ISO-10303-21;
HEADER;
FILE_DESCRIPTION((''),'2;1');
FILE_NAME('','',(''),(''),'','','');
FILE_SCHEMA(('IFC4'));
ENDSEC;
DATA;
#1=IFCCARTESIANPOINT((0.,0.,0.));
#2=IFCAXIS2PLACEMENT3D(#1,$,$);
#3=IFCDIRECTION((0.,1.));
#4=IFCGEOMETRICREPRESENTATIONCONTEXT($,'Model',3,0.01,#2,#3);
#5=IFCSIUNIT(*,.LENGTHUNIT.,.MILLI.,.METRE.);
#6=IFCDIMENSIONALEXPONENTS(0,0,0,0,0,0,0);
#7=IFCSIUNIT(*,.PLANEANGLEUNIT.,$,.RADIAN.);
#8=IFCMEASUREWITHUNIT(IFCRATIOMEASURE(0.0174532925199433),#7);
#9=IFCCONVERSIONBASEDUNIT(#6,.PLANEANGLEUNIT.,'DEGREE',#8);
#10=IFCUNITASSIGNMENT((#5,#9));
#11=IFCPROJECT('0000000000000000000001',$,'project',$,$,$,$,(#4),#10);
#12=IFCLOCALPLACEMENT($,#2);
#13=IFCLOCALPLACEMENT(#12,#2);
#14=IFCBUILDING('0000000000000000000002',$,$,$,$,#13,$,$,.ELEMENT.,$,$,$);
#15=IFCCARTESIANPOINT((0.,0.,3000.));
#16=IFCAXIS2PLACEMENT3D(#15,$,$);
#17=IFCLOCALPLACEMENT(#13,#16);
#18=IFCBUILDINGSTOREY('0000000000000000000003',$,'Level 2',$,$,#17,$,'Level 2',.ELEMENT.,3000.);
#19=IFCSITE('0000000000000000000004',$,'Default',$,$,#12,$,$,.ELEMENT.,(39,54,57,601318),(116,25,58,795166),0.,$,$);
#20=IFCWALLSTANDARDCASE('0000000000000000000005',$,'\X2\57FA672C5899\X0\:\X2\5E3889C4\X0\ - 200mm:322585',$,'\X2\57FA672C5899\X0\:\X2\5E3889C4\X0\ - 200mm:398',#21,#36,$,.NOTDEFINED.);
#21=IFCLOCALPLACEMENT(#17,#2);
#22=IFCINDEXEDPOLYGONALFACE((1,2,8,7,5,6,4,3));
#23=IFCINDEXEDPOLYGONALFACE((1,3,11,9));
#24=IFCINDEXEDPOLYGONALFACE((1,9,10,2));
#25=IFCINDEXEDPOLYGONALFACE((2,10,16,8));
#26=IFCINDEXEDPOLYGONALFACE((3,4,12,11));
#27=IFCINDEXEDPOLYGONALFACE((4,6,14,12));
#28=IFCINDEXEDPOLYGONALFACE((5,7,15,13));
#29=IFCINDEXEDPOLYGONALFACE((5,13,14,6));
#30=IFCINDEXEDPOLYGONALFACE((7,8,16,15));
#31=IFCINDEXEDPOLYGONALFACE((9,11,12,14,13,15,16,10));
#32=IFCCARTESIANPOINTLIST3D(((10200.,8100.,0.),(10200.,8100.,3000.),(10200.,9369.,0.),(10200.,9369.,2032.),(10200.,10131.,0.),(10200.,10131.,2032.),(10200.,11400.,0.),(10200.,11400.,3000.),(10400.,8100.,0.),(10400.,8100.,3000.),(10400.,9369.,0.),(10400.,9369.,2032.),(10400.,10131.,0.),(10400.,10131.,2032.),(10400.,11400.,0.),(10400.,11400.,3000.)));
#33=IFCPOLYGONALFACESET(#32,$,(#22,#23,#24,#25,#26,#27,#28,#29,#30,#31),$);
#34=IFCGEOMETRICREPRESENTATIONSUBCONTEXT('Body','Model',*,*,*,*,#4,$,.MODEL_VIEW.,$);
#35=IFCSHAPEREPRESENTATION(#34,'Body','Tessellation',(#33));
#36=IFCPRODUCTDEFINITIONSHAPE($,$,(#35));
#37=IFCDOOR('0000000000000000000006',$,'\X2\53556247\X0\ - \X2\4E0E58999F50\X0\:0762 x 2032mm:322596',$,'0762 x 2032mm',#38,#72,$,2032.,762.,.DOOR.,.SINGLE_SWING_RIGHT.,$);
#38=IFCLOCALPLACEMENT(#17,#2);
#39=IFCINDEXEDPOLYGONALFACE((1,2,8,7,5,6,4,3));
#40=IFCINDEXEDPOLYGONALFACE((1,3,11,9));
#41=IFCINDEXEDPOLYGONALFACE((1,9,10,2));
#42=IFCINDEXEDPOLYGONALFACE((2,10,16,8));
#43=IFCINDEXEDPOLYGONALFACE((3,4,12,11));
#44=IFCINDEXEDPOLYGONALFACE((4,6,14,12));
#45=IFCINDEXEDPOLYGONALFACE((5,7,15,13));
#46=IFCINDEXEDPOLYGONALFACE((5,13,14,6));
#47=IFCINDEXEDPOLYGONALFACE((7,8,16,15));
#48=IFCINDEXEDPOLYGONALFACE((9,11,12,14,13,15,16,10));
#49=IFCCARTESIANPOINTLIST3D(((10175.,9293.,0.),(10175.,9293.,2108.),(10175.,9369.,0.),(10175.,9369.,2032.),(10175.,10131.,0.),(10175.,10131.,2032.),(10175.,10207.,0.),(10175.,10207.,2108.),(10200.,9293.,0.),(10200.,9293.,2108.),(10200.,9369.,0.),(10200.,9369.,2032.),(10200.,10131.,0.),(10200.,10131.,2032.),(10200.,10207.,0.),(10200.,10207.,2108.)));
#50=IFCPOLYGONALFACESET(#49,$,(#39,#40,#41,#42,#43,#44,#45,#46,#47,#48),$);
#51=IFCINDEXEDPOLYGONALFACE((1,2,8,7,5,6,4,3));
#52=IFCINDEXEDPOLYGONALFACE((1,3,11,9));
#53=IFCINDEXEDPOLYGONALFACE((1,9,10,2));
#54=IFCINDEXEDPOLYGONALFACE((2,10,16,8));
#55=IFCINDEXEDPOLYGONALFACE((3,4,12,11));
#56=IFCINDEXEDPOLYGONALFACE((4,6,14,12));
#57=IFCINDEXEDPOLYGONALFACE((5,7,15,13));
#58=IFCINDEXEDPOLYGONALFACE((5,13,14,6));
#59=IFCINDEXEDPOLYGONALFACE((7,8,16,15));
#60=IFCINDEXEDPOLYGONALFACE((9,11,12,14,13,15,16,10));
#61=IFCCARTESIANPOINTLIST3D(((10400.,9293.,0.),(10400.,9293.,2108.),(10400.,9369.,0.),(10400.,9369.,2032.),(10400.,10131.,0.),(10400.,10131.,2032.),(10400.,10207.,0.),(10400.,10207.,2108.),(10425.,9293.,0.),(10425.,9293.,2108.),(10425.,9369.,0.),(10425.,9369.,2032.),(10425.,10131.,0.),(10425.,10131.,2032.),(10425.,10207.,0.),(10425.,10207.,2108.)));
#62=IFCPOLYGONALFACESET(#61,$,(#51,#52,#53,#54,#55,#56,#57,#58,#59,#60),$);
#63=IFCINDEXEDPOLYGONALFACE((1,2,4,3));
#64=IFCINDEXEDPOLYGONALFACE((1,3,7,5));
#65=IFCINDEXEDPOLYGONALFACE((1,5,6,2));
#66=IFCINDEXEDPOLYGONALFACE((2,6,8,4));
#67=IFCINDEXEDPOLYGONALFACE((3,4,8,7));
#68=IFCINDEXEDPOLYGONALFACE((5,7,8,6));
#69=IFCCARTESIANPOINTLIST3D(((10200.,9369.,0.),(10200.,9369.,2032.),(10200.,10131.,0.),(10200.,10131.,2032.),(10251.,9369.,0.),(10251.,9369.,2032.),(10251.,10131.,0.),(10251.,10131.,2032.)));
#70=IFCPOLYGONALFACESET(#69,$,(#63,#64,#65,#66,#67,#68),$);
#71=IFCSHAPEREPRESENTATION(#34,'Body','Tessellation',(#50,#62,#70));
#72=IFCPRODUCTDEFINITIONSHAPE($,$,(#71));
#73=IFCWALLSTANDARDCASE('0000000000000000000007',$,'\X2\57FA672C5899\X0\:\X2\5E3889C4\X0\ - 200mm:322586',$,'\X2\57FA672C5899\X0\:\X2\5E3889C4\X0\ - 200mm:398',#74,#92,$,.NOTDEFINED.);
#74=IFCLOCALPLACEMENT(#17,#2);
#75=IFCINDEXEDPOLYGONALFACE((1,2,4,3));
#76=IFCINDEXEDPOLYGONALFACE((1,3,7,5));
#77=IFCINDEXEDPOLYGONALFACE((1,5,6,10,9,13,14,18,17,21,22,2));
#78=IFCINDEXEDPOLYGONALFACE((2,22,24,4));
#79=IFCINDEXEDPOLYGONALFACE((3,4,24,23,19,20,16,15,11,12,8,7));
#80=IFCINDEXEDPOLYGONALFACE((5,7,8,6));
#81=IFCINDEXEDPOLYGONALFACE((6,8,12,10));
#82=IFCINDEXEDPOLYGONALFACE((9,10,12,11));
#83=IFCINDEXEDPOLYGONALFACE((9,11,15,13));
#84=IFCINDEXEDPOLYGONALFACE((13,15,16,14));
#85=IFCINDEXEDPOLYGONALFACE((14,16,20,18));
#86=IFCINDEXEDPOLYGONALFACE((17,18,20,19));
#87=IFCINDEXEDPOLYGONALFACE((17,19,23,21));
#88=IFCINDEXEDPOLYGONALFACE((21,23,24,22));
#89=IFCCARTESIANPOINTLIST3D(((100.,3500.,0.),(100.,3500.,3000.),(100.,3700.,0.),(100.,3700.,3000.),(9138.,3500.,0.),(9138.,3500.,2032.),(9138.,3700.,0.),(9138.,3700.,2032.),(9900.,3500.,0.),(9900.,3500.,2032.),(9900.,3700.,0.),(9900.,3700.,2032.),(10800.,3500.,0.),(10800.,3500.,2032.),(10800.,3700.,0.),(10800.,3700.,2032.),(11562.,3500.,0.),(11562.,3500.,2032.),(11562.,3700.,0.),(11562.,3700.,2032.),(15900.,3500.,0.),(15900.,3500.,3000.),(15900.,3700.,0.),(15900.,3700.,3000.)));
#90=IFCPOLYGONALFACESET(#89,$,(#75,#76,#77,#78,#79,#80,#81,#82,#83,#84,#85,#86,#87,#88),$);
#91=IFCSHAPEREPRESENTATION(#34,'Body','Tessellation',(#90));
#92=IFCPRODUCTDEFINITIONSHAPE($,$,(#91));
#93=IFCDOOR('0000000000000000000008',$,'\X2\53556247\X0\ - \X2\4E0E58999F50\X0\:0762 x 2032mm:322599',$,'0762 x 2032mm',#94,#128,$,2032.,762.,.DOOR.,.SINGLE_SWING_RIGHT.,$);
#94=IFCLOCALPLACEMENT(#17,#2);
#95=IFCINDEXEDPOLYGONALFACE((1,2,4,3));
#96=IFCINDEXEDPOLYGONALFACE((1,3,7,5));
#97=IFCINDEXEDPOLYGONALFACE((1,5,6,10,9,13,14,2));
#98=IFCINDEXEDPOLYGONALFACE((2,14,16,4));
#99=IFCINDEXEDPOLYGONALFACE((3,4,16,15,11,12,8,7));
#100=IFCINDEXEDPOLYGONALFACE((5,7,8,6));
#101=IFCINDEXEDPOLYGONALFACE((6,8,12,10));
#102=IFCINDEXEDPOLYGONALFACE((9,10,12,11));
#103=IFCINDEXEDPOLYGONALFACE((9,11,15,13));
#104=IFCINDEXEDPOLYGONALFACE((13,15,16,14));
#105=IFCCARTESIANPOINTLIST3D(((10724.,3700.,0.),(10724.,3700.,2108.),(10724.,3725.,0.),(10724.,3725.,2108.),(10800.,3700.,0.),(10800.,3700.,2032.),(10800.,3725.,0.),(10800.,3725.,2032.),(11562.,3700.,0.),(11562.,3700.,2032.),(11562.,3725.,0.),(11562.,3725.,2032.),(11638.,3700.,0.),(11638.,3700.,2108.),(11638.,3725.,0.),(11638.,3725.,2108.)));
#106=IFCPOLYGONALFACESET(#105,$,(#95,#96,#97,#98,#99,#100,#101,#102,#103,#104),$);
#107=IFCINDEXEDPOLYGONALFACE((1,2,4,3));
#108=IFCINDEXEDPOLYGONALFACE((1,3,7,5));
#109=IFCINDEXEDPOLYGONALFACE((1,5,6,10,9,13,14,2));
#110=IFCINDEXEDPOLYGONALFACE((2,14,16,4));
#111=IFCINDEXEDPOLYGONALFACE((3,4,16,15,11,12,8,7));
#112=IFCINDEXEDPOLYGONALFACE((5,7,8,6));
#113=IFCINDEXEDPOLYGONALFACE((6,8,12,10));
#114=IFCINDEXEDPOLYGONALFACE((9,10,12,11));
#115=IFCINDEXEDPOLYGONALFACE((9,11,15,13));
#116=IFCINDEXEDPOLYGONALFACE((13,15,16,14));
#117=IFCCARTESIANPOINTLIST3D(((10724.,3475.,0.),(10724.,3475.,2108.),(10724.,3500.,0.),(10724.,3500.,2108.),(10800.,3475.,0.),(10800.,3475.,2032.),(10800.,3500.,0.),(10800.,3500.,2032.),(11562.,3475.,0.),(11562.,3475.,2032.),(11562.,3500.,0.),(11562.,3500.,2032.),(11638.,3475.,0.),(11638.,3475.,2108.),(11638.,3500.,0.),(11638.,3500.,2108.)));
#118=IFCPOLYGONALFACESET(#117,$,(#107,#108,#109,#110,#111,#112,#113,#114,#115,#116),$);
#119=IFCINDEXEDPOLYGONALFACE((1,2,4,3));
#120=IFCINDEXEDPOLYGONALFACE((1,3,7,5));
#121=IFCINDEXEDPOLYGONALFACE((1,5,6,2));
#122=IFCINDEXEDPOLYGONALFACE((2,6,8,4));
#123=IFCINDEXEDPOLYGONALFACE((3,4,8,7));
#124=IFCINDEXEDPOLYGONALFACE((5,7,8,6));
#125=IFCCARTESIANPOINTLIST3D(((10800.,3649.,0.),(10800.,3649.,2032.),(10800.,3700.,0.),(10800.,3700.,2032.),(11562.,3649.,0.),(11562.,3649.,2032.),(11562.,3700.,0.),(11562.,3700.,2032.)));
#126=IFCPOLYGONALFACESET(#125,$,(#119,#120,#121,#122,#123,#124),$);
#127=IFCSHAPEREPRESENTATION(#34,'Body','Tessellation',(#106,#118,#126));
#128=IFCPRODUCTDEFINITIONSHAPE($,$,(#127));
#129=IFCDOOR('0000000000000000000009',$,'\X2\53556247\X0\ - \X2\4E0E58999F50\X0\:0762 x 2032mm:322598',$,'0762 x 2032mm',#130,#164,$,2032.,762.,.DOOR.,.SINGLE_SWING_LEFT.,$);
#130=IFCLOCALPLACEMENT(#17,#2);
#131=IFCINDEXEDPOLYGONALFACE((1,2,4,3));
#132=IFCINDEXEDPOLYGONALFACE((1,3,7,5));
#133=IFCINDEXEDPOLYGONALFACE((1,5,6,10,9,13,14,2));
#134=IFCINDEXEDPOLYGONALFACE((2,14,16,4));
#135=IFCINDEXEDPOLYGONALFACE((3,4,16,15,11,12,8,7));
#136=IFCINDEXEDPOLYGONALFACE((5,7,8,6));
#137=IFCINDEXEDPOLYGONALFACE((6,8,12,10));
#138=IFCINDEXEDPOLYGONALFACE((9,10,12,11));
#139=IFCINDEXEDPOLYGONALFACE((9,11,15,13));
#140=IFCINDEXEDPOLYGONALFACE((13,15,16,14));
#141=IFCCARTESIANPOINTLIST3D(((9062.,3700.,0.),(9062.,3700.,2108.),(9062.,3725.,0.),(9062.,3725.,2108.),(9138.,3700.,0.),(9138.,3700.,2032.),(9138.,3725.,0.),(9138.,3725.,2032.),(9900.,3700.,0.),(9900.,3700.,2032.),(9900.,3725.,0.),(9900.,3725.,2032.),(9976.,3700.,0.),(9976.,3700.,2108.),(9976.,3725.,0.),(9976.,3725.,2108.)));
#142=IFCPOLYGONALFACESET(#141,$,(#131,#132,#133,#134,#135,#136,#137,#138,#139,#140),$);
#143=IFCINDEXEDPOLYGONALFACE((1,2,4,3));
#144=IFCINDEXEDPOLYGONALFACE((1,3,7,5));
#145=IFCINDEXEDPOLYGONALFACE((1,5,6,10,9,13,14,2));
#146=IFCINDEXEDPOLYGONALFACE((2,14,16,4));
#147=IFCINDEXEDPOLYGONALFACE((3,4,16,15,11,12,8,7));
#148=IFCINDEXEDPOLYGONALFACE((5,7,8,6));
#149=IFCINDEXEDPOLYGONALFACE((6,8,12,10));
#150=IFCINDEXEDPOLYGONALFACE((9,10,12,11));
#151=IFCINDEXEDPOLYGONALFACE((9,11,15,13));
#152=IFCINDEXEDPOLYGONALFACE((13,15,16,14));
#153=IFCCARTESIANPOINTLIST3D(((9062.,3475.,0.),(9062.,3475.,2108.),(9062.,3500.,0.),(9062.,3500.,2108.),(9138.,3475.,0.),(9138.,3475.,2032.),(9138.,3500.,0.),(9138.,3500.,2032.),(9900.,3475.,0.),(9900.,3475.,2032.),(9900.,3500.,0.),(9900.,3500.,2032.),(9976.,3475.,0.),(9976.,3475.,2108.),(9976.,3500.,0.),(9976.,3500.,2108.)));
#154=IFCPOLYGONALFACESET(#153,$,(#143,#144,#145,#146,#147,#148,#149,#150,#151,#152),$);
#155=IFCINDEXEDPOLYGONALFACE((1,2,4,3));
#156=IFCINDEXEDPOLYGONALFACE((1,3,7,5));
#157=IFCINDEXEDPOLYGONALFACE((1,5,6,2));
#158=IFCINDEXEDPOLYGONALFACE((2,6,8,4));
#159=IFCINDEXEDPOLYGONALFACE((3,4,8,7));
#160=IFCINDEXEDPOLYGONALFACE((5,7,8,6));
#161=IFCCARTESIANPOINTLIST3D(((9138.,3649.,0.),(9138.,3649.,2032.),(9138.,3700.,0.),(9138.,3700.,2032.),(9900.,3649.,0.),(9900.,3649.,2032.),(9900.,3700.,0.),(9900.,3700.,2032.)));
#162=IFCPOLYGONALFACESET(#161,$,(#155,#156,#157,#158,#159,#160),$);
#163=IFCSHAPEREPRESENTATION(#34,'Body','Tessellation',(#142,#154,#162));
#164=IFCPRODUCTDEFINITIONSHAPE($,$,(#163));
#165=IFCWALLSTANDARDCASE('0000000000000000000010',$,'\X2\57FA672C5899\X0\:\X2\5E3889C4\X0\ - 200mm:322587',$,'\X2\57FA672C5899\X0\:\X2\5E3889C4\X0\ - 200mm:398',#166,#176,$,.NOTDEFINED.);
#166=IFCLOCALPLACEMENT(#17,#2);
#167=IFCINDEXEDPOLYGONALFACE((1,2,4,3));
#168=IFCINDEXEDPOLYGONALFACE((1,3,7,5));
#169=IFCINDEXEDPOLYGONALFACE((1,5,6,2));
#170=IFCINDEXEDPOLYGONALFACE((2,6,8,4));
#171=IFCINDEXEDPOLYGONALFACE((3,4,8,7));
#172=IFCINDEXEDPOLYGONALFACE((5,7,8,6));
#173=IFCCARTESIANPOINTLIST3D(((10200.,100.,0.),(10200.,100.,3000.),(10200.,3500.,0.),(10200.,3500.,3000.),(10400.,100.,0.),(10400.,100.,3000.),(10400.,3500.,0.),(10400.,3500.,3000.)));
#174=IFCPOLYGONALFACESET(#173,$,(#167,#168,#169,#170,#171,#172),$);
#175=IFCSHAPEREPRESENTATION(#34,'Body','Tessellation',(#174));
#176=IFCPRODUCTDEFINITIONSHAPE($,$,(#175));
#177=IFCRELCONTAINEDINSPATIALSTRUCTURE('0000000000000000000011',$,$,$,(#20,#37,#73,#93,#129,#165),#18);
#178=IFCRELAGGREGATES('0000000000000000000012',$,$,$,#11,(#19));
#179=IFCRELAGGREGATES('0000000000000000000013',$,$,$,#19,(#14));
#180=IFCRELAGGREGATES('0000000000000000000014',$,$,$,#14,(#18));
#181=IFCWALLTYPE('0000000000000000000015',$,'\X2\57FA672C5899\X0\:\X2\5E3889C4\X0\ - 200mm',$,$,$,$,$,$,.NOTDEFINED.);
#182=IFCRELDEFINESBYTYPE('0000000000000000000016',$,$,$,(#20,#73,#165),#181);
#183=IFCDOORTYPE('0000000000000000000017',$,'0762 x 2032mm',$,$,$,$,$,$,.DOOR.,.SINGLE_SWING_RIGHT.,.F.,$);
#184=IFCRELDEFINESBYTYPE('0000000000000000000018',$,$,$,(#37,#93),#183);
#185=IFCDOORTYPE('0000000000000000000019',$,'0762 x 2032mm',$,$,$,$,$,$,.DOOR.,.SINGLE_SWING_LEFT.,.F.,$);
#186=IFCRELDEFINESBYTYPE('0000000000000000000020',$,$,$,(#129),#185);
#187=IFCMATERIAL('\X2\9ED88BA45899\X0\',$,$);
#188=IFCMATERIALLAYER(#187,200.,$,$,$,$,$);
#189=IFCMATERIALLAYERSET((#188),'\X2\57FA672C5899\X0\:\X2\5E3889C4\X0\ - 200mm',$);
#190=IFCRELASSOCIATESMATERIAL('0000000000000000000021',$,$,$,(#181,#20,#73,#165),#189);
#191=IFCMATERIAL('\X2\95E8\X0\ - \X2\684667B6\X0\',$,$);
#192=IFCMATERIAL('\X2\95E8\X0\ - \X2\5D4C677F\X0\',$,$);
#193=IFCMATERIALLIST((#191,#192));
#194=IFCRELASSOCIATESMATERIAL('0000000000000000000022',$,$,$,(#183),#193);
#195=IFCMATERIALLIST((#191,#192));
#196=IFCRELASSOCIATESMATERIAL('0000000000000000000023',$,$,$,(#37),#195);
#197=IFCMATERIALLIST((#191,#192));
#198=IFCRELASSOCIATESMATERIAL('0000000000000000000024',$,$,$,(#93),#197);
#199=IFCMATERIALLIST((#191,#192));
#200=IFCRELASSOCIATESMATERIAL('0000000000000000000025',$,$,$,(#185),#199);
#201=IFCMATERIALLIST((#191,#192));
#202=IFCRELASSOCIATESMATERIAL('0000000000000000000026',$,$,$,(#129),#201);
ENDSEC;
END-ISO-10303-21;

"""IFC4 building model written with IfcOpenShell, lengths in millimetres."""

from ifc_helpers import new_model, entity, si_unit, converted_unit, direction, frame, frame_2d, origin, place, context, subcontext, project, spatial, polyline, rectangle, outline, extrude, source, transform, mapped, material, material_list, layer, layer_set, layer_usage, type_object, type_shapes, element, fill, save


model = new_model("IFC4")

# Units and contexts
model_context_1 = context("Model", 3, precision=0.01, world=origin(), true_north=direction((0.0, 1.0)))
body_context_1 = subcontext(model_context_1, "Body", "Model", "MODEL_VIEW")
ifc_project = project(units=[si_unit("LENGTHUNIT", "METRE", prefix="MILLI"), converted_unit("PLANEANGLEUNIT", "DEGREE", entity("IfcRatioMeasure", 0.0174532925199433), si_unit("PLANEANGLEUNIT", "RADIAN"), dimensions=[0, 0, 0, 0, 0, 0, 0])], contexts=[model_context_1])

# Site, building, storey
site_placement = place(None, origin())
site = spatial("IfcSite", under=ifc_project, at=site_placement, Name="Default", CompositionType="ELEMENT", RefLatitude=(39, 54, 57, 601318), RefLongitude=(116, 25, 58, 795166), RefElevation=0.0)
building_placement = place(site_placement, origin())
building = spatial("IfcBuilding", under=site, at=building_placement, CompositionType="ELEMENT")
storey_placement = place(building_placement, frame((0.0, 0.0, 3000.0)))
storey = spatial("IfcBuildingStorey", under=building, at=storey_placement, Name="Level 2", LongName="Level 2", CompositionType="ELEMENT", Elevation=3000.0)

# Shared definitions
ifc_material_1 = material(Name="默认墙")
ifc_layer = layer(ifc_material_1, 200.0)
ifc_layer_set = layer_set([ifc_layer], Name="基本墙:常规 - 200mm")
wall_type = type_object("IfcWallType", Name="基本墙:常规 - 200mm", PredefinedType="NOTDEFINED", material=ifc_layer_set)

# Wall, opening, door
ifc_layer_usage_1 = layer_usage(ifc_layer_set, "AXIS2", "NEGATIVE", 100.0)
wall_1_placement = place(storey_placement, frame((10300.0, 11400.0, 0.0), z_axis=(0.0, 0.0, 1.0), x_axis=(0.0, -1.0, 0.0)))
wall_1 = element("IfcWallStandardCase", 1, at=wall_1_placement, inside=storey, type_object=wall_type, material=ifc_layer_usage_1, Name="基本墙:常规 - 200mm:322585", ObjectType="基本墙:常规 - 200mm:398", PredefinedType="NOTDEFINED", context=body_context_1, shape_type="SweptSolid", body=[
    extrude(rectangle(XDim=3300.0, YDim=200.0, at=frame_2d((1650.0, 0.0), x_axis=(-1.0, 0.0))), origin(), (0.0, 0.0, 1.0), 3000.0),
])
opening_1_placement = place(wall_1_placement, frame((2031.0, 100.0, 0.0)))
opening_1 = element("IfcOpeningElement", 2, at=opening_1_placement, cuts=wall_1, ObjectType="Opening", PredefinedType="OPENING", context=body_context_1, shape_type="SweptSolid", body=[
    extrude(rectangle(XDim=762.0, YDim=2032.0, at=frame_2d((1016.0, 381.0), x_axis=(0.0, 1.0))), frame((0.0, 0.0, 0.0), z_axis=(0.0, -1.0, 0.0), x_axis=(0.0, 0.0, 1.0)), (0.0, 0.0, 1.0), 200.0),
])
ifc_material_2 = material(Name="门 - 框架")
ifc_material_3 = material(Name="门 - 嵌板")
ifc_material_list_1 = material_list([ifc_material_2, ifc_material_3])
ifc_material_list_2 = material_list([ifc_material_2, ifc_material_3])
door_type_1 = type_object("IfcDoorType", Name="0762 x 2032mm", OperationType="SINGLE_SWING_RIGHT", ParameterTakesPrecedence=False, PredefinedType="DOOR", material=ifc_material_list_2)
shared_shape_1 = source(origin(), body_context_1, "Body", "SweptSolid", [
    extrude(outline(polyline([(-457.0, -1073.0), (457.0, -1073.0), (457.0, 1035.0), (381.0, 1035.0), (381.0, -997.0), (-381.0, -997.0), (-381.0, 1035.0), (-457.0, 1035.0), (-457.0, -1073.0)])), frame((381.0, 200.0, 1035.0), z_axis=(0.0, 1.0, 0.0), x_axis=(1.0, 0.0, 0.0)), (0.0, 0.0, 1.0), 25.0),
    extrude(outline(polyline([(-1073.0, -457.0), (1035.0, -457.0), (1035.0, -381.0), (-997.0, -381.0), (-997.0, 381.0), (1035.0, 381.0), (1035.0, 457.0), (-1073.0, 457.0), (-1073.0, -457.0)])), frame((381.0, -25.0, 1035.0), z_axis=(0.0, 1.0, 0.0), x_axis=(0.0, 0.0, -1.0)), (0.0, 0.0, 1.0), 25.0),
    extrude(rectangle(XDim=51.0, YDim=762.0, at=frame_2d((0.0, 0.0), x_axis=(1.0, 0.0))), frame((381.0, 174.5, 0.0), z_axis=(0.0, 0.0, 1.0), x_axis=(0.0, 1.0, 0.0)), (0.0, 0.0, 1.0), 2032.0),
])
type_shapes(door_type_1, [shared_shape_1])
door_1_placement = place(opening_1_placement, frame((0.0, 0.0, 0.0), z_axis=(0.0, 0.0, 1.0), x_axis=(-1.0, 0.0, 0.0)))
door_1 = element("IfcDoor", 3, at=door_1_placement, inside=storey, type_object=door_type_1, material=ifc_material_list_1, Name="单扇 - 与墙齐:0762 x 2032mm:322596", ObjectType="0762 x 2032mm", OperationType="SINGLE_SWING_RIGHT", OverallHeight=2032.0, OverallWidth=762.0, PredefinedType="DOOR", context=body_context_1, shape_type="MappedRepresentation", body=[
    mapped(shared_shape_1, transform((0.0, 0.0, 0.0), scale=1.0)),
])
fill(opening_1, door_1)

# Wall, openings, doors
ifc_layer_usage_2 = layer_usage(ifc_layer_set, "AXIS2", "NEGATIVE", 100.0)
wall_2_placement = place(storey_placement, frame((15900.0, 3600.0, 0.0), z_axis=(0.0, 0.0, 1.0), x_axis=(-1.0, 0.0, 0.0)))
wall_2 = element("IfcWallStandardCase", 4, at=wall_2_placement, inside=storey, type_object=wall_type, material=ifc_layer_usage_2, Name="基本墙:常规 - 200mm:322586", ObjectType="基本墙:常规 - 200mm:398", PredefinedType="NOTDEFINED", context=body_context_1, shape_type="SweptSolid", body=[
    extrude(rectangle(XDim=15800.0, YDim=200.0, at=frame_2d((7900.0, 0.0), x_axis=(-1.0, 0.0))), origin(), (0.0, 0.0, 1.0), 3000.0),
])
opening_2_placement = place(wall_2_placement, frame((6762.0, 100.0, 0.0)))
opening_2 = element("IfcOpeningElement", 5, at=opening_2_placement, cuts=wall_2, ObjectType="Opening", PredefinedType="OPENING", context=body_context_1, shape_type="SweptSolid", body=[
    extrude(rectangle(XDim=762.0, YDim=2032.0, at=frame_2d((1016.0, 381.0), x_axis=(0.0, -1.0))), frame((0.0, 0.0, 0.0), z_axis=(0.0, -1.0, 0.0), x_axis=(0.0, 0.0, 1.0)), (0.0, 0.0, 1.0), 200.0),
])
opening_3_placement = place(wall_2_placement, frame((5100.0, 100.0, 0.0)))
opening_3 = element("IfcOpeningElement", 6, at=opening_3_placement, cuts=wall_2, ObjectType="Opening", PredefinedType="OPENING", context=body_context_1, shape_type="SweptSolid", body=[
    extrude(rectangle(XDim=762.0, YDim=2032.0, at=frame_2d((1016.0, 381.0), x_axis=(0.0, 1.0))), frame((0.0, 0.0, 0.0), z_axis=(0.0, -1.0, 0.0), x_axis=(0.0, 0.0, 1.0)), (0.0, 0.0, 1.0), 200.0),
])
ifc_material_list_3 = material_list([ifc_material_2, ifc_material_3])
door_2_placement = place(opening_3_placement, frame((0.0, 0.0, 0.0), z_axis=(0.0, 0.0, 1.0), x_axis=(-1.0, 0.0, 0.0)))
door_2 = element("IfcDoor", 7, at=door_2_placement, inside=storey, type_object=door_type_1, material=ifc_material_list_3, Name="单扇 - 与墙齐:0762 x 2032mm:322599", ObjectType="0762 x 2032mm", OperationType="SINGLE_SWING_RIGHT", OverallHeight=2032.0, OverallWidth=762.0, PredefinedType="DOOR", context=body_context_1, shape_type="MappedRepresentation", body=[
    mapped(shared_shape_1, transform((0.0, 0.0, 0.0), scale=1.0)),
])
fill(opening_3, door_2)
ifc_material_list_4 = material_list([ifc_material_2, ifc_material_3])
ifc_material_list_5 = material_list([ifc_material_2, ifc_material_3])
door_type_2 = type_object("IfcDoorType", Name="0762 x 2032mm", OperationType="SINGLE_SWING_LEFT", ParameterTakesPrecedence=False, PredefinedType="DOOR", material=ifc_material_list_5)
shared_shape_2 = source(origin(), body_context_1, "Body", "SweptSolid", [
    extrude(outline(polyline([(-457.0, -1073.0), (457.0, -1073.0), (457.0, 1035.0), (381.0, 1035.0), (381.0, -997.0), (-381.0, -997.0), (-381.0, 1035.0), (-457.0, 1035.0), (-457.0, -1073.0)])), frame((381.0, 225.0, 1035.0), z_axis=(0.0, -1.0, 0.0), x_axis=(-1.0, 0.0, 0.0)), (0.0, 0.0, 1.0), 25.0),
    extrude(outline(polyline([(-1073.0, -457.0), (1035.0, -457.0), (1035.0, -381.0), (-997.0, -381.0), (-997.0, 381.0), (1035.0, 381.0), (1035.0, 457.0), (-1073.0, 457.0), (-1073.0, -457.0)])), frame((381.0, 0.0, 1035.0), z_axis=(0.0, -1.0, 0.0), x_axis=(0.0, 0.0, -1.0)), (0.0, 0.0, 1.0), 25.0),
    extrude(rectangle(XDim=762.0, YDim=51.0, at=frame_2d((0.0, 0.0), x_axis=(1.0, 0.0))), frame((381.0, 174.5, 0.0)), (0.0, 0.0, 1.0), 2032.0),
])
type_shapes(door_type_2, [shared_shape_2])
door_3_placement = place(opening_2_placement, frame((0.0, 0.0, 0.0), z_axis=(0.0, 0.0, 1.0), x_axis=(-1.0, 0.0, 0.0)))
door_3 = element("IfcDoor", 8, at=door_3_placement, inside=storey, type_object=door_type_2, material=ifc_material_list_4, Name="单扇 - 与墙齐:0762 x 2032mm:322598", ObjectType="0762 x 2032mm", OperationType="SINGLE_SWING_LEFT", OverallHeight=2032.0, OverallWidth=762.0, PredefinedType="DOOR", context=body_context_1, shape_type="MappedRepresentation", body=[
    mapped(shared_shape_2, transform((0.0, 0.0, 0.0), scale=1.0)),
])
fill(opening_2, door_3)

# Wall
ifc_layer_usage_3 = layer_usage(ifc_layer_set, "AXIS2", "NEGATIVE", 100.0)
wall_3_placement = place(storey_placement, frame((10300.0, 3500.0, 0.0), z_axis=(0.0, 0.0, 1.0), x_axis=(0.0, -1.0, 0.0)))
element("IfcWallStandardCase", 9, at=wall_3_placement, inside=storey, type_object=wall_type, material=ifc_layer_usage_3, Name="基本墙:常规 - 200mm:322587", ObjectType="基本墙:常规 - 200mm:398", PredefinedType="NOTDEFINED", context=body_context_1, shape_type="SweptSolid", body=[
    extrude(rectangle(XDim=3400.0, YDim=200.0, at=frame_2d((1700.0, 0.0), x_axis=(-1.0, 0.0))), origin(), (0.0, 0.0, 1.0), 3000.0),
])

save(model, "model.ifc")
